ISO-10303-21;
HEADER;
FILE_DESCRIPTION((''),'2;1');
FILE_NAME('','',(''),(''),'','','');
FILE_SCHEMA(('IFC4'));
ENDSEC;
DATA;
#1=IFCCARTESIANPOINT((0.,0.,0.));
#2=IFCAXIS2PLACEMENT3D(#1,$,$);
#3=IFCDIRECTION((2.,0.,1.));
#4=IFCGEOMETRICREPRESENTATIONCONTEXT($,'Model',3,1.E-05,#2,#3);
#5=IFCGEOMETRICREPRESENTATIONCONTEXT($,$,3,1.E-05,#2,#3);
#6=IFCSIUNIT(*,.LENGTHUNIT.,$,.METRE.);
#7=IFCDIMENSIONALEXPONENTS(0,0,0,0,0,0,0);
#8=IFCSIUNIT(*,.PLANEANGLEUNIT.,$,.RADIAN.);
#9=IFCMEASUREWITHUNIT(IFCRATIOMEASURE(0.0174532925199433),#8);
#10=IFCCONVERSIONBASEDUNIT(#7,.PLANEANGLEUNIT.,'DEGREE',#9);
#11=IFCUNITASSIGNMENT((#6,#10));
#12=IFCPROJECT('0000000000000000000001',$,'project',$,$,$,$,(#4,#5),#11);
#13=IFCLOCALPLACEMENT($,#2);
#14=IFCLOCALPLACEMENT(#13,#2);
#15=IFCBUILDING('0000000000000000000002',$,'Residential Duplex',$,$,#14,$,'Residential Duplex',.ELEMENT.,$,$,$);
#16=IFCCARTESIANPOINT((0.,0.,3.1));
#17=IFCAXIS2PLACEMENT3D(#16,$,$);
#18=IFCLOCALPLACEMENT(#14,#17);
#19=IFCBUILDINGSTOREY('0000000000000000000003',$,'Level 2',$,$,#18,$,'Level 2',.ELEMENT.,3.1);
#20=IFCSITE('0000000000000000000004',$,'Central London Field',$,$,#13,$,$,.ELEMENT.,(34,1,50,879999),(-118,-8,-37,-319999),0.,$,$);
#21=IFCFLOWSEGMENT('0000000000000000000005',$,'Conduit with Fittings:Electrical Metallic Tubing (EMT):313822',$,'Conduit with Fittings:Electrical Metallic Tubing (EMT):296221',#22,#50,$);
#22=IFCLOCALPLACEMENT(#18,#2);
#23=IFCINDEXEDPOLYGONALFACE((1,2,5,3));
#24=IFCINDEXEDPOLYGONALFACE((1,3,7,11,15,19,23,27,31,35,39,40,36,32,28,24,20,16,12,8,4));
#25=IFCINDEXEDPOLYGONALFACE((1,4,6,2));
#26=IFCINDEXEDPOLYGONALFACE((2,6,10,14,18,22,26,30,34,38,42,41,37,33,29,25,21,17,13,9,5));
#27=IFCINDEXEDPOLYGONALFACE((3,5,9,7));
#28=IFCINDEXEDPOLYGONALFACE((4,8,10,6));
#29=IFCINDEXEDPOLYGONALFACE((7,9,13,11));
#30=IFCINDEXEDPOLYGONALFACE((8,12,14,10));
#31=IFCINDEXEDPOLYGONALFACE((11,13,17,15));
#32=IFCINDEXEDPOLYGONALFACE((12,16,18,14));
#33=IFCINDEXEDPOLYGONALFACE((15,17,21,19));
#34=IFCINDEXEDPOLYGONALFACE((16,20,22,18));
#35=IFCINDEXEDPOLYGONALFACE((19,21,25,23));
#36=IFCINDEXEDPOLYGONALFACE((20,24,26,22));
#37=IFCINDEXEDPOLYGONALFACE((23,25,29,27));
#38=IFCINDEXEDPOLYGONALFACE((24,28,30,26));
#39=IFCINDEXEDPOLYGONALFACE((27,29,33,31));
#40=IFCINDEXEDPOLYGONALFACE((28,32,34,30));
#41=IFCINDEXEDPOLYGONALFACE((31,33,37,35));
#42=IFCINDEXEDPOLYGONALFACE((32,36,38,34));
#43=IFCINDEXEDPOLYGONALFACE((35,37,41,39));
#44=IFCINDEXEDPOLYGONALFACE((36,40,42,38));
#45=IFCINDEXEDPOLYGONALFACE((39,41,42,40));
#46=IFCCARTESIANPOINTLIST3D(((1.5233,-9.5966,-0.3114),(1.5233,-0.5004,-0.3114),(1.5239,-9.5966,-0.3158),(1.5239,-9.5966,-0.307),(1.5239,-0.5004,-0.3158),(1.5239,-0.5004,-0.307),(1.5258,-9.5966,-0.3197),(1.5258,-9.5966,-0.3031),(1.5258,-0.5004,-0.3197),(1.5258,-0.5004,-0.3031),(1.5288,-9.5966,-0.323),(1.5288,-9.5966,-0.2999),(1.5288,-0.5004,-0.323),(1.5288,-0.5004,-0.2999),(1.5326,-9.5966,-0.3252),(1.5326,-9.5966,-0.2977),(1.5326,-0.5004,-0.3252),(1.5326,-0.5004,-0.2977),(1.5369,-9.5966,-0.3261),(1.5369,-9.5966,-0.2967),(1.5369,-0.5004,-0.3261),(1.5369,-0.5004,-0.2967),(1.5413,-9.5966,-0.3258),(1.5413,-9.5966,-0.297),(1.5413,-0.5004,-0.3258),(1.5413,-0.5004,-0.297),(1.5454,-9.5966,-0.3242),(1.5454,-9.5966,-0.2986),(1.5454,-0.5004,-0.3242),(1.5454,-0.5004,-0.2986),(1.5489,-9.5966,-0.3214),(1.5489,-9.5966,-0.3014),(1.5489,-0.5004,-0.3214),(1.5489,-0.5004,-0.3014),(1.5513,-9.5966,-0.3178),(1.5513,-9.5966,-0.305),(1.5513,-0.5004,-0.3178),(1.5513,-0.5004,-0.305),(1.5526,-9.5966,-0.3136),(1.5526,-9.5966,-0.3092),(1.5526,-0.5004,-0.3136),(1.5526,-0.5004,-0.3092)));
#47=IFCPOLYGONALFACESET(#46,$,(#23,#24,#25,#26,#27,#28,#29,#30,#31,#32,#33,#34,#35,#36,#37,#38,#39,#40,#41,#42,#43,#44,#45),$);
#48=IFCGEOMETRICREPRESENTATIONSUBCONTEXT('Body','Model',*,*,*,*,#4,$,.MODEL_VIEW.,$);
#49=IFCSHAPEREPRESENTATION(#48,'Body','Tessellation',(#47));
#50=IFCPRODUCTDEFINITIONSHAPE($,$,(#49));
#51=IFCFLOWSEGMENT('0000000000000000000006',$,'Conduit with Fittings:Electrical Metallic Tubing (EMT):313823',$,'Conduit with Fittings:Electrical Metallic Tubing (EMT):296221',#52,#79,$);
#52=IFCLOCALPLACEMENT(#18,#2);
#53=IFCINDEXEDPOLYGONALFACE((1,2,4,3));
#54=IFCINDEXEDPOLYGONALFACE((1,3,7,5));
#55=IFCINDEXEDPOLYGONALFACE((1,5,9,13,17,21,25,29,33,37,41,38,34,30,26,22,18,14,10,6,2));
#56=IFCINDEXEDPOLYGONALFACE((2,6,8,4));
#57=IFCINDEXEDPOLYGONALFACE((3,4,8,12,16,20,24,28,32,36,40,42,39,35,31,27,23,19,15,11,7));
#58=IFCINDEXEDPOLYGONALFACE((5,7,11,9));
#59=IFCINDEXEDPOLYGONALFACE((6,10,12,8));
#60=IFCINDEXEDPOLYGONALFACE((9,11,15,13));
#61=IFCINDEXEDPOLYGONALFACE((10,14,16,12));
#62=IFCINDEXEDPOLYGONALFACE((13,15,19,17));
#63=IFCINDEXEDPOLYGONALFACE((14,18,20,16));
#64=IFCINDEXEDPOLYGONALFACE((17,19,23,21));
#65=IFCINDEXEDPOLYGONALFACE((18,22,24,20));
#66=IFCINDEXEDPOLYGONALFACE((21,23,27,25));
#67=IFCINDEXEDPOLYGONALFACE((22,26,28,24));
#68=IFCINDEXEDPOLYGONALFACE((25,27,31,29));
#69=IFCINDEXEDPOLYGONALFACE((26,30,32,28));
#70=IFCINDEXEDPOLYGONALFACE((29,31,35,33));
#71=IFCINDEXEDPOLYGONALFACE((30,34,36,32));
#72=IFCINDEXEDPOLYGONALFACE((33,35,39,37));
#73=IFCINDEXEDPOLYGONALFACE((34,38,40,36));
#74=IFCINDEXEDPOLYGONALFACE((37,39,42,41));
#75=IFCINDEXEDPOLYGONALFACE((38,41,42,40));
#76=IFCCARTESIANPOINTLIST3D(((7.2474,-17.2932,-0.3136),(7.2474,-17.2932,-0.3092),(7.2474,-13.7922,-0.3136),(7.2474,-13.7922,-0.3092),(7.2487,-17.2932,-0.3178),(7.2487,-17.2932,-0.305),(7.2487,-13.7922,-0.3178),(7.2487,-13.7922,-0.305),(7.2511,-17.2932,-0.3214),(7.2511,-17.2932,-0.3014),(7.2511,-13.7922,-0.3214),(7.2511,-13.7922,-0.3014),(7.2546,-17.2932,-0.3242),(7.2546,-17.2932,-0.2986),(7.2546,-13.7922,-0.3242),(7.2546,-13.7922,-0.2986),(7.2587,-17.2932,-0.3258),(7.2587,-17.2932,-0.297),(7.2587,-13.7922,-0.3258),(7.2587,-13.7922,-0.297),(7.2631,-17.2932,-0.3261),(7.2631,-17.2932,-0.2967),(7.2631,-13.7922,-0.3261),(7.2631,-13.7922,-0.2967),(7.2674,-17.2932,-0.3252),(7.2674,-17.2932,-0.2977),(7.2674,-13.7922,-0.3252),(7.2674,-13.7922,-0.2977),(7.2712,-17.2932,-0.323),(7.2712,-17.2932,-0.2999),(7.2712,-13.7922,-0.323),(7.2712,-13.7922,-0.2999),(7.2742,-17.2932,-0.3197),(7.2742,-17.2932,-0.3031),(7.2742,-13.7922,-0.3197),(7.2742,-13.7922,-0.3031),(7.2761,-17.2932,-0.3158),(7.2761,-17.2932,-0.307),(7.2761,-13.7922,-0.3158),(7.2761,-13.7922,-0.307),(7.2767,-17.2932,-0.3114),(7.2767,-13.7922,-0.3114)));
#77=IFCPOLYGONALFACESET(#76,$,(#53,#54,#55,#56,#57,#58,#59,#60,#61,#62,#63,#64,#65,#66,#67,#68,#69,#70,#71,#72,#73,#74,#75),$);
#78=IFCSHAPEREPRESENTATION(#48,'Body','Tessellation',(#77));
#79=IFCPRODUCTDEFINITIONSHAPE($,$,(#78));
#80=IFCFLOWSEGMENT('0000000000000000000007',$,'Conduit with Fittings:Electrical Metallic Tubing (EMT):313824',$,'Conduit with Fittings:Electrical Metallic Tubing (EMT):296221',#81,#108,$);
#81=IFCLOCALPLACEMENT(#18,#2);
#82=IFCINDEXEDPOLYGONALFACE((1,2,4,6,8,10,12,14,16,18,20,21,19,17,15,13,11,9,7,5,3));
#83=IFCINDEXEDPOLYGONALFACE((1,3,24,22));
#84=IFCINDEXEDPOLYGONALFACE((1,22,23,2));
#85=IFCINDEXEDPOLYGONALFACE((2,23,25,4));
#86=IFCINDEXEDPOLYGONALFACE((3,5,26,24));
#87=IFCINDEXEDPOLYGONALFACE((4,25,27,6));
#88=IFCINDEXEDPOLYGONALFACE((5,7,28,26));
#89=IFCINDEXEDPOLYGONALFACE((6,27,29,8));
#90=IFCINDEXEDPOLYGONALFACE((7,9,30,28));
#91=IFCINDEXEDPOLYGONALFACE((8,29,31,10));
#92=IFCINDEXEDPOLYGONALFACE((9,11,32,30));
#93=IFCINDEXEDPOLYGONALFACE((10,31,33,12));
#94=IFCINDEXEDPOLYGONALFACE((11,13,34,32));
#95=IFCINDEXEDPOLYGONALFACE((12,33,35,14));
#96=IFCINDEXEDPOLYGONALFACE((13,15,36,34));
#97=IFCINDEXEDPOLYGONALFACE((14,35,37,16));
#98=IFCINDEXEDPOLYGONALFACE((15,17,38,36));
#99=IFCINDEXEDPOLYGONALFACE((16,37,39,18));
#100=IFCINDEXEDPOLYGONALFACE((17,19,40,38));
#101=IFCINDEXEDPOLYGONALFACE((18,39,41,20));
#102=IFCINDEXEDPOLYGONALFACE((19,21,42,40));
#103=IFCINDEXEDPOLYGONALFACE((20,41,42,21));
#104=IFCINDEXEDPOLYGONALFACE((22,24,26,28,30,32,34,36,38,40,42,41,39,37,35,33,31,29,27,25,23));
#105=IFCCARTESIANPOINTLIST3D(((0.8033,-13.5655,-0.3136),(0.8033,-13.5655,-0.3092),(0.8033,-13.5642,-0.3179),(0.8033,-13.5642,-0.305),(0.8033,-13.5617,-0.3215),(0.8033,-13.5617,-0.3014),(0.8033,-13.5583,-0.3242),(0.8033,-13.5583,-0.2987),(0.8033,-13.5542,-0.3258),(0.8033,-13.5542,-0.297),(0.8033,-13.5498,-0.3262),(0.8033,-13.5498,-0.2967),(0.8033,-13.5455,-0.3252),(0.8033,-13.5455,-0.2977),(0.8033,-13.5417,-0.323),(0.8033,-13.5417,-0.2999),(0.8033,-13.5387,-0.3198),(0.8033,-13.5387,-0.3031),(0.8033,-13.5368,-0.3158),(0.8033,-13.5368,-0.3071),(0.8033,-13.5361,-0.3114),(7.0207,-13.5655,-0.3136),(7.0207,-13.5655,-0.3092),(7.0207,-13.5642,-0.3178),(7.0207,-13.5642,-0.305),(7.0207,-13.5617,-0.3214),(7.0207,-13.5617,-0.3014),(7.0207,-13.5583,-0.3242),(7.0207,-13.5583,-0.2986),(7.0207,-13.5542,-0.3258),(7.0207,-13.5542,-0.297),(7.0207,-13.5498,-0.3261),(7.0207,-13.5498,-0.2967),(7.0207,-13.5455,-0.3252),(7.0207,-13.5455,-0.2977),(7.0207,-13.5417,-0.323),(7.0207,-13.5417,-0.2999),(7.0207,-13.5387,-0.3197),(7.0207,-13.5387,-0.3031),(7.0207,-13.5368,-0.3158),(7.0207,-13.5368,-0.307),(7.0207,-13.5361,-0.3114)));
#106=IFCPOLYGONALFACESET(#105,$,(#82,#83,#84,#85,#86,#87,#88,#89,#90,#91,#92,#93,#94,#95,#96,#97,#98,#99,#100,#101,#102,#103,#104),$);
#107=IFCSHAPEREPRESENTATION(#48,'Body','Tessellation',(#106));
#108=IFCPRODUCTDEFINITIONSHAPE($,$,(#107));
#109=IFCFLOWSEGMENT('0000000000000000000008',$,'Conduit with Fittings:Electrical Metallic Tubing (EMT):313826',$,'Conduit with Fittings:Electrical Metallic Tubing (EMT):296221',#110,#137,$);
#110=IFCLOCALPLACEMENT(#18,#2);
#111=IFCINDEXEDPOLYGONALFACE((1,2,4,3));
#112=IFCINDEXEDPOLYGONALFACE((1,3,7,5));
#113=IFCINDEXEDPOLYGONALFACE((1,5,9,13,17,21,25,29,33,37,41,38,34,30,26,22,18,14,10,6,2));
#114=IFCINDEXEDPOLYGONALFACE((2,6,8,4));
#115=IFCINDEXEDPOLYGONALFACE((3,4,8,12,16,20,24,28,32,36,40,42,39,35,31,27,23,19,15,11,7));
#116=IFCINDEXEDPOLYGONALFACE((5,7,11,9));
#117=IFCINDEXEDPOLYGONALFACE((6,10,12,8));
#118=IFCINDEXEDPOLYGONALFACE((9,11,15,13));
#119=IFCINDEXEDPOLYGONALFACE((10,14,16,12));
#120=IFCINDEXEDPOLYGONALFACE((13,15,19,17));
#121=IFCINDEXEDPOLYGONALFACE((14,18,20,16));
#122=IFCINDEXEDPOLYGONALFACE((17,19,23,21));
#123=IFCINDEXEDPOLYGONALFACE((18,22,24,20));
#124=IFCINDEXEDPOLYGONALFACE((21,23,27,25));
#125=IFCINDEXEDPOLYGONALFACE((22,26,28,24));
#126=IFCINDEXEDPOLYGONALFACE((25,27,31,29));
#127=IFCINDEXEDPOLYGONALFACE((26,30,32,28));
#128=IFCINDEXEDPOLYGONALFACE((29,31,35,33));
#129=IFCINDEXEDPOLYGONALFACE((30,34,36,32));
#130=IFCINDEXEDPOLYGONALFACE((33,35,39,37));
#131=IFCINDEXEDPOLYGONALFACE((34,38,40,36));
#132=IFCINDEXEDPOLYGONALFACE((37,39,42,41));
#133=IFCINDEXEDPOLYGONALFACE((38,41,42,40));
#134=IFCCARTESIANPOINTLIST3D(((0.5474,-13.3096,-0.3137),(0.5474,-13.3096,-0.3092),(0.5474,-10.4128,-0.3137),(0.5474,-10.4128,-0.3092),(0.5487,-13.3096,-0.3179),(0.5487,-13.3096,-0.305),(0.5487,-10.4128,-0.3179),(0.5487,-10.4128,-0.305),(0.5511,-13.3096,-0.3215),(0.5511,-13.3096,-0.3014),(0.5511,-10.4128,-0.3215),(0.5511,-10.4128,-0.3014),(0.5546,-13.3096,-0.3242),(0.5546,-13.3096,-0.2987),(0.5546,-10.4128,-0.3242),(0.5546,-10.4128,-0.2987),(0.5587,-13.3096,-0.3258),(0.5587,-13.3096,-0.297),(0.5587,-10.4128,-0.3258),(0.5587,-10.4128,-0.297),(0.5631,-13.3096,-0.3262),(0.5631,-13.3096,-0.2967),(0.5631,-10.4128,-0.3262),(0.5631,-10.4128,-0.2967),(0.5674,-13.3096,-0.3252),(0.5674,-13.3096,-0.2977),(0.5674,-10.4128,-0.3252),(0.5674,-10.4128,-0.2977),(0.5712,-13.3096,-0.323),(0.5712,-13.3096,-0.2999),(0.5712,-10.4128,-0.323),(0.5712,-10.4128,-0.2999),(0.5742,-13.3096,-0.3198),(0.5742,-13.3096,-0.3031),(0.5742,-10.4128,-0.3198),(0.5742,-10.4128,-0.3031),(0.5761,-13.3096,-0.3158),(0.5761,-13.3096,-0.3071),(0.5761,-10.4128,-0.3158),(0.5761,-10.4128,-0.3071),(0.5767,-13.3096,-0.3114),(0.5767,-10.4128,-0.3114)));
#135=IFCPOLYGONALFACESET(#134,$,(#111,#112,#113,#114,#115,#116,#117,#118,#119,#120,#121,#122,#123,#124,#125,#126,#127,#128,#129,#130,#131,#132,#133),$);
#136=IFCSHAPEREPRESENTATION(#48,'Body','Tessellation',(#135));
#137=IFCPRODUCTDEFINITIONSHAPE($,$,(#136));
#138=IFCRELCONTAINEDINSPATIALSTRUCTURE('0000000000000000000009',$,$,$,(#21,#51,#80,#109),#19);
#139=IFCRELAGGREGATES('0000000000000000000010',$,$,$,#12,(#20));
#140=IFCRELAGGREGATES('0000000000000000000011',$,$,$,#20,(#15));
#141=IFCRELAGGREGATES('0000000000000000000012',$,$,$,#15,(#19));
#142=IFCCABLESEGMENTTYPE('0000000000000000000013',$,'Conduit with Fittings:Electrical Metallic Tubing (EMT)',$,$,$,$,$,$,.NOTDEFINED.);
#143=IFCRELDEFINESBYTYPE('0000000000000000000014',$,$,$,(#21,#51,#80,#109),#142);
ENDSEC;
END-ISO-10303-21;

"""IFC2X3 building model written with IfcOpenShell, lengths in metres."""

from ifc_helpers import new_model, entity, si_unit, converted_unit, direction, frame, frame_2d, origin, origin_2d_with_axis, place, context, subcontext, project, spatial, circle, extrude, type_object, element, save


model = new_model("IFC2X3")

# Units and contexts
model_context = context("Model", 3, precision=1e-05, world=origin(), true_north=direction((2.0, 0.0, 1.0)))
context_of_model = context(None, 3, precision=1e-05, world=origin(), true_north=direction((2.0, 0.0, 1.0)))
body_context = subcontext(model_context, "Body", "Model", "MODEL_VIEW")
ifc_project = project(units=[si_unit("LENGTHUNIT", "METRE"), converted_unit("PLANEANGLEUNIT", "DEGREE", entity("IfcRatioMeasure", 0.0174532925199433), si_unit("PLANEANGLEUNIT", "RADIAN"), dimensions=[0, 0, 0, 0, 0, 0, 0])], contexts=[model_context, context_of_model])

# Site, building, storey
site_placement = place(None, origin())
site = spatial("IfcSite", under=ifc_project, at=site_placement, Name="Central London Field", CompositionType="ELEMENT", RefLatitude=(34, 1, 50, 879999), RefLongitude=(-118, -8, -37, -319999), RefElevation=0.0)
building_placement = place(site_placement, origin())
building = spatial("IfcBuilding", under=site, at=building_placement, Name="Residential Duplex", LongName="Residential Duplex", CompositionType="ELEMENT")
storey_placement = place(building_placement, frame((0.0, 0.0, 3.1)))
storey = spatial("IfcBuildingStorey", under=building, at=storey_placement, Name="Level 2", LongName="Level 2", CompositionType="ELEMENT", Elevation=3.1)

# Flow segments
cable_segment_type = type_object("IfcCableSegmentType", Name="Conduit with Fittings:Electrical Metallic Tubing (EMT)", PredefinedType="NOTDEFINED")
flow_segment_1_placement = place(storey_placement, origin())
element("IfcFlowSegment", 1, at=flow_segment_1_placement, inside=storey, type_object=cable_segment_type, Name="Conduit with Fittings:Electrical Metallic Tubing (EMT):313822", ObjectType="Conduit with Fittings:Electrical Metallic Tubing (EMT):296221", context=body_context, shape_type="SweptSolid", body=[
    extrude(circle(Radius=0.0148, at=frame_2d((0.0, 0.0), x_axis=(1.0, 0.0))), frame((1.538, -9.5966, -0.3114), z_axis=(0.0, 1.0, 0.0), x_axis=(-1.0, 0.0, 0.0)), (0.0, 0.0, 1.0), 9.0962),
])
flow_segment_2_placement = place(storey_placement, origin())
element("IfcFlowSegment", 2, at=flow_segment_2_placement, inside=storey, type_object=cable_segment_type, Name="Conduit with Fittings:Electrical Metallic Tubing (EMT):313823", ObjectType="Conduit with Fittings:Electrical Metallic Tubing (EMT):296221", context=body_context, shape_type="SweptSolid", body=[
    extrude(circle(Radius=0.0148, at=origin_2d_with_axis()), frame((7.262, -17.2932, -0.3114), z_axis=(0.0, 1.0, 0.0), x_axis=(1.0, 0.0, 0.0)), (0.0, 0.0, 1.0), 3.501),
])
flow_segment_3_placement = place(storey_placement, origin())
element("IfcFlowSegment", 3, at=flow_segment_3_placement, inside=storey, type_object=cable_segment_type, Name="Conduit with Fittings:Electrical Metallic Tubing (EMT):313824", ObjectType="Conduit with Fittings:Electrical Metallic Tubing (EMT):296221", context=body_context, shape_type="SweptSolid", body=[
    extrude(circle(Radius=0.0148, at=frame_2d((0.0, 0.0), x_axis=(1.0, 0.0))), frame((0.8033, -13.5509, -0.3114), z_axis=(1.0, 0.0, 0.000007), x_axis=(0.0, 1.0, 0.0)), (0.0, 0.0, 1.0), 6.2174),
])
flow_segment_4_placement = place(storey_placement, origin())
element("IfcFlowSegment", 4, at=flow_segment_4_placement, inside=storey, type_object=cable_segment_type, Name="Conduit with Fittings:Electrical Metallic Tubing (EMT):313826", ObjectType="Conduit with Fittings:Electrical Metallic Tubing (EMT):296221", context=body_context, shape_type="SweptSolid", body=[
    extrude(circle(Radius=0.0148, at=origin_2d_with_axis()), frame((0.562, -13.3096, -0.3114), z_axis=(0.0, 1.0, 0.0), x_axis=(1.0, 0.0, 0.000007)), (0.0, 0.0, 1.0), 2.8968),
])

save(model, "model.ifc")
